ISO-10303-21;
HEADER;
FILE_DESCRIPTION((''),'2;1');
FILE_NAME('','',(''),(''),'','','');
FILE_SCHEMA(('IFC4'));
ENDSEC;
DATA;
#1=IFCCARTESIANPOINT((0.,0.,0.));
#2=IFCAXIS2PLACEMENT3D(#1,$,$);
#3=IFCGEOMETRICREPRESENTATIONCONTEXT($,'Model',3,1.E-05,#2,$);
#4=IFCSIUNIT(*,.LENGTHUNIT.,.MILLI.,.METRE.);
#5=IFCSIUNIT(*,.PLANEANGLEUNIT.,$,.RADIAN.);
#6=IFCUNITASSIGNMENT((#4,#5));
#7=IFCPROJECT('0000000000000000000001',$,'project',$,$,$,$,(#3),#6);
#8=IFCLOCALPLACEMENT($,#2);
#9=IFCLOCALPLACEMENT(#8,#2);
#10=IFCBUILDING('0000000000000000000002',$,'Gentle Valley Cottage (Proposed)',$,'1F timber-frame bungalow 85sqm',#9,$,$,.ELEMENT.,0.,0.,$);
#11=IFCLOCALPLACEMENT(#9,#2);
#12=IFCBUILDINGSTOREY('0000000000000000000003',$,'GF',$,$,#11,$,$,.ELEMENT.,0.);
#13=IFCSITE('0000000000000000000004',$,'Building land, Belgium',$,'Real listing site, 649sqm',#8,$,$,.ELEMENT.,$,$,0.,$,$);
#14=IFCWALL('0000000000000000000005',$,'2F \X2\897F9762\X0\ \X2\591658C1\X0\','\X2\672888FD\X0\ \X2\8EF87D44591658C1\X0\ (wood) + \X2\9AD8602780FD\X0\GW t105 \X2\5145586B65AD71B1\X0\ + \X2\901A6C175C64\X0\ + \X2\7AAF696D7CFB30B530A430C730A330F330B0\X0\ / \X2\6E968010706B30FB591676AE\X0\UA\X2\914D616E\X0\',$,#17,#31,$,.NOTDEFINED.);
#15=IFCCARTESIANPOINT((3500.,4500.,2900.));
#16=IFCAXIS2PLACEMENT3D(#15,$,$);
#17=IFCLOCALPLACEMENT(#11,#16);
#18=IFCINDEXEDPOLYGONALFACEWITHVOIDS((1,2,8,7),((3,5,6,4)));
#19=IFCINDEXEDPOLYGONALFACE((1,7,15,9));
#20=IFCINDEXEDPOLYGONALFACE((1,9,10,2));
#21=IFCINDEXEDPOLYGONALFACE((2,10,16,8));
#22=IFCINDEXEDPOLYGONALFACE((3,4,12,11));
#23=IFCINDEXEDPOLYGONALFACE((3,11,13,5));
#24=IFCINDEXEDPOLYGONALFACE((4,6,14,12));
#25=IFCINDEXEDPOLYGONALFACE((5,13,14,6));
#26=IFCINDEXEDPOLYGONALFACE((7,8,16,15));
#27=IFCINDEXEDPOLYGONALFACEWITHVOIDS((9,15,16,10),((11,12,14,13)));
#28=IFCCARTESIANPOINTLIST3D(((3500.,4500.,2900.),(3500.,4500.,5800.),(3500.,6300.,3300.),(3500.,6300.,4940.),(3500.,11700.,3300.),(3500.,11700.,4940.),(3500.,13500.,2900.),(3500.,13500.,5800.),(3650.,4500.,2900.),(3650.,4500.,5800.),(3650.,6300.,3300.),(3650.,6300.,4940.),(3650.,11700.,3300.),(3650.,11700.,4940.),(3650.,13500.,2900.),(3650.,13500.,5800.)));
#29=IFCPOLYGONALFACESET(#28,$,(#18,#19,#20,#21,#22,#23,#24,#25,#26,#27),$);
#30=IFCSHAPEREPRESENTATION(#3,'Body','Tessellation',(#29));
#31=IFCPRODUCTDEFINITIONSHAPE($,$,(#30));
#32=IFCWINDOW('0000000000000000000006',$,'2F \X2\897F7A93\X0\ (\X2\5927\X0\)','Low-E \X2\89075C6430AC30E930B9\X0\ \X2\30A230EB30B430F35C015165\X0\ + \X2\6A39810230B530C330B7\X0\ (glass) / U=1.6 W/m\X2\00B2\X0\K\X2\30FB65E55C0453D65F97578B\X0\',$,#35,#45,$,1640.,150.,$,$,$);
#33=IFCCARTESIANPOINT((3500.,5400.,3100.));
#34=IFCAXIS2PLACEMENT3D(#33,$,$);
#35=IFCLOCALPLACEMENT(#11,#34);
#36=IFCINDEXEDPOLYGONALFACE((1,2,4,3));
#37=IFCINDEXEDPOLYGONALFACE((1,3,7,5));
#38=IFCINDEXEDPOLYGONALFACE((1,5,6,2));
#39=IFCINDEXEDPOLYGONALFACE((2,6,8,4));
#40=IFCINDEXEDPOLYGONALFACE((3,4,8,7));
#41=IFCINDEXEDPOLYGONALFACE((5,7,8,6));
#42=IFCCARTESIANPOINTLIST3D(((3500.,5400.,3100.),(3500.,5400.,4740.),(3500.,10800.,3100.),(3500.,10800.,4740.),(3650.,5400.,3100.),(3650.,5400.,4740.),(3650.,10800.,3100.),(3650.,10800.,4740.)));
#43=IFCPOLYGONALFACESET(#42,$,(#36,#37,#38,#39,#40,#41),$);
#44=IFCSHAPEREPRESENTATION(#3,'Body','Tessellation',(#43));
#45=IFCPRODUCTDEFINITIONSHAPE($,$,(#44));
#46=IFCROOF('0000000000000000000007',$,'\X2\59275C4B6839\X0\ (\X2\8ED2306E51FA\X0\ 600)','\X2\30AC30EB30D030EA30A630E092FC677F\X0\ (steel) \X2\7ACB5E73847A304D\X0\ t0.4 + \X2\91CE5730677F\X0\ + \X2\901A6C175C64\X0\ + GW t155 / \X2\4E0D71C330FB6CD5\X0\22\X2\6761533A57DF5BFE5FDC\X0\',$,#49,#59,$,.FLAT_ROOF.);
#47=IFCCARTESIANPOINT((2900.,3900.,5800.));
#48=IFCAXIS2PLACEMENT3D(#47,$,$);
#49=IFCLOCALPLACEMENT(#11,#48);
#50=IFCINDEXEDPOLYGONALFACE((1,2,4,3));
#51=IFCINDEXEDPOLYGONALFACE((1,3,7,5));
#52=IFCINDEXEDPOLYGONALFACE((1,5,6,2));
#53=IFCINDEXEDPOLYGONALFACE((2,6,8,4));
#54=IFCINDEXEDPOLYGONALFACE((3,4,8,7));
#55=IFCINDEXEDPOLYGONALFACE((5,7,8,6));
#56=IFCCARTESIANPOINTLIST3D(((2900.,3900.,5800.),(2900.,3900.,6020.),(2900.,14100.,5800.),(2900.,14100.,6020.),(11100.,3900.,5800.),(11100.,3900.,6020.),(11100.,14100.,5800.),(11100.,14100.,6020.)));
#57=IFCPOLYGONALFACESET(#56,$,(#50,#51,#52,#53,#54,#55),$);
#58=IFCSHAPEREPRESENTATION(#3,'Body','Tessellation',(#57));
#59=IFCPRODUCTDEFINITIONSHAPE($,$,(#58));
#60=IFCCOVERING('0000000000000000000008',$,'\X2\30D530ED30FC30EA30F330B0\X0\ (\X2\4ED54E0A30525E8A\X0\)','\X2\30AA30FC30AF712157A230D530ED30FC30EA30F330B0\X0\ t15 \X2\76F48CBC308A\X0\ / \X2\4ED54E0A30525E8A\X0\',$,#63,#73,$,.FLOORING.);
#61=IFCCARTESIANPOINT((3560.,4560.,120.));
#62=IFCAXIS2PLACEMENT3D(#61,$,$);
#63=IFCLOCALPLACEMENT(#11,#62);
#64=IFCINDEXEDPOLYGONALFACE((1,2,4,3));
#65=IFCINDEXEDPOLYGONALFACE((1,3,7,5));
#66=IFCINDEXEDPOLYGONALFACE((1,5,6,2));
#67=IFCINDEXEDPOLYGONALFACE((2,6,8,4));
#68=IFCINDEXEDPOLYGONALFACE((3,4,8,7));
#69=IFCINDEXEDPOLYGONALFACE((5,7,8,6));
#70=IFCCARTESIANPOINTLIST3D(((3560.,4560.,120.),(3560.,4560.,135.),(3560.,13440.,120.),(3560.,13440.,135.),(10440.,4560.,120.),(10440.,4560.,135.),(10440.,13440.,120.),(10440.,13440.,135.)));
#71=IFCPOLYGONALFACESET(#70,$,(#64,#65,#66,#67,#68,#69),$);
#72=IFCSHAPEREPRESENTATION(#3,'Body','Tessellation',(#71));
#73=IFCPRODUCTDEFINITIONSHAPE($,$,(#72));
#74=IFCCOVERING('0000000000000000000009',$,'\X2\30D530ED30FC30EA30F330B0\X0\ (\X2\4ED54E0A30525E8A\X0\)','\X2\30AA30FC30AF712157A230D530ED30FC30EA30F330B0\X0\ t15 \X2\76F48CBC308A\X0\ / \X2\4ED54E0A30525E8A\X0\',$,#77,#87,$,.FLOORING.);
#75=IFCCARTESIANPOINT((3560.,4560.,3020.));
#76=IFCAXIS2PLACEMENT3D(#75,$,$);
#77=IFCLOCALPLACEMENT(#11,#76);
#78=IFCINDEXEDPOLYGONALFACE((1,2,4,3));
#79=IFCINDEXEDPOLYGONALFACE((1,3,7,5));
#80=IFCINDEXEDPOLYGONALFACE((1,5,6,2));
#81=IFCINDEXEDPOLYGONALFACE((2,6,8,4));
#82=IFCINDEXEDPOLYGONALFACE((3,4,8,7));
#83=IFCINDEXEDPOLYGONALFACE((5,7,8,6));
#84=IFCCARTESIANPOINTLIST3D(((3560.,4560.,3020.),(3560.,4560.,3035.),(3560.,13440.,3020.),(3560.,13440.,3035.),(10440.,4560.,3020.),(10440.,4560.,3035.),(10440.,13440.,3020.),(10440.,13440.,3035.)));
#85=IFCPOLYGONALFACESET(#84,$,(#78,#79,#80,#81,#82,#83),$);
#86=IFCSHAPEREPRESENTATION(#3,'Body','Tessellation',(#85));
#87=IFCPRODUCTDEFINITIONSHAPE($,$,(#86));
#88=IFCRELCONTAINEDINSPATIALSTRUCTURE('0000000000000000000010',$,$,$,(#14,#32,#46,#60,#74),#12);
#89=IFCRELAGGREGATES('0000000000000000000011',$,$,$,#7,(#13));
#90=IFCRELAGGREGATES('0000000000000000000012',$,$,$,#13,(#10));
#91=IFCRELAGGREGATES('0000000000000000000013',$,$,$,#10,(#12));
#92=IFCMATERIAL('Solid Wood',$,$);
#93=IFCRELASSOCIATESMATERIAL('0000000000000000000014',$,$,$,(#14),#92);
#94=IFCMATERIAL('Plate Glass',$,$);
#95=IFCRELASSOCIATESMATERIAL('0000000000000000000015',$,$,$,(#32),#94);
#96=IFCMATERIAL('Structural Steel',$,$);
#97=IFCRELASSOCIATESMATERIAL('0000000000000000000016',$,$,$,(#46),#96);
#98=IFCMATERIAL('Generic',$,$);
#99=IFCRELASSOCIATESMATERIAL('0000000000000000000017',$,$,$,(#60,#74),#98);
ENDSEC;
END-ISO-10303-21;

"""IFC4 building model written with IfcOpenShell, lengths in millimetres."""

from ifc_helpers import new_model, si_unit, frame, frame_2d, origin, place, context, project, spatial, rectangle, extrude, material, element, fill, save


model = new_model("IFC4")

# Units and contexts
model_context = context("Model", 3, precision=1e-05, world=origin())
ifc_project = project(units=[si_unit("LENGTHUNIT", "METRE", prefix="MILLI"), si_unit("PLANEANGLEUNIT", "RADIAN")], contexts=[model_context])

# Site, building, storey
site_placement = place(None, origin())
site = spatial("IfcSite", under=ifc_project, at=site_placement, Name="Building land, Belgium", ObjectType="Real listing site, 649sqm", CompositionType="ELEMENT", RefElevation=0.0)
building_placement = place(site_placement, origin())
building = spatial("IfcBuilding", under=site, at=building_placement, Name="Gentle Valley Cottage (Proposed)", ObjectType="1F timber-frame bungalow 85sqm", CompositionType="ELEMENT", ElevationOfRefHeight=0.0, ElevationOfTerrain=0.0)
storey_placement = place(building_placement, origin())
storey = spatial("IfcBuildingStorey", under=building, at=storey_placement, Name="GF", CompositionType="ELEMENT", Elevation=0.0)

# Shared definitions
ifc_material_1 = material(Name="Solid Wood")
ifc_material_2 = material(Name="Generic")

# Shared definitions
ifc_material_3 = material(Name="Plate Glass")

# Wall, opening, window
wall_1_placement = place(storey_placement, frame((3500.0, 4500.0, 2900.0)))
wall_1 = element("IfcWall", 1, at=wall_1_placement, inside=storey, material=ifc_material_1, Name="2F 西面 外壁", Description="木製 軸組外壁 (wood) + 高性能GW t105 充填断熱 + 通気層 + 窯業系サイディング / 準耐火・外皮UA配慮", PredefinedType="NOTDEFINED", context=model_context, shape_type="SweptSolid", body=[
    extrude(rectangle(XDim=150.0, YDim=9000.0, at=frame_2d((75.0, 4500.0))), frame((3500.0, 4500.0, 2900.0)), (0.0, 0.0, 1.0), 2900.0),
])
opening_1_placement = place(storey_placement, frame((3500.0, 5400.0, 3100.0)))
opening_1 = element("IfcOpeningElement", 2, at=opening_1_placement, cuts=wall_1, PredefinedType="NOTDEFINED", context=model_context, shape_type="SweptSolid", body=[
    extrude(rectangle(XDim=150.0, YDim=5400.0, at=frame_2d((75.0, 2700.0))), frame((3500.0, 5400.0, 3100.0)), (0.0, 0.0, 1.0), 1640.0),
])
window_1_placement = place(storey_placement, frame((3500.0, 5400.0, 3100.0)))
window_1 = element("IfcWindow", 3, at=window_1_placement, inside=storey, material=ifc_material_3, Name="2F 西窓 (大)", Description="Low-E 複層ガラス アルゴン封入 + 樹脂サッシ (glass) / U=1.6 W/m²K・日射取得型", OverallHeight=1640.0, OverallWidth=150.0, context=model_context, shape_type="SweptSolid", body=[
    extrude(rectangle(XDim=150.0, YDim=5400.0, at=frame_2d((75.0, 2700.0))), frame((3500.0, 5400.0, 3100.0)), (0.0, 0.0, 1.0), 1640.0),
])
fill(opening_1, window_1)

# Roof
ifc_material_4 = material(Name="Structural Steel")
roof_placement = place(storey_placement, frame((2900.0, 3900.0, 5800.0)))
element("IfcRoof", 4, at=roof_placement, inside=storey, material=ifc_material_4, Name="大屋根 (軒の出 600)", Description="ガルバリウム鋼板 (steel) 立平葺き t0.4 + 野地板 + 通気層 + GW t155 / 不燃・法22条区域対応", PredefinedType="FLAT_ROOF", context=model_context, shape_type="SweptSolid", body=[
    extrude(rectangle(XDim=8200.0, YDim=10200.0, at=frame_2d((4100.0, 5100.0))), frame((2900.0, 3900.0, 5800.0)), (0.0, 0.0, 1.0), 220.0),
])

# Coverings
covering_1_placement = place(storey_placement, frame((3560.0, 4560.0, 120.0)))
element("IfcCovering", 5, at=covering_1_placement, inside=storey, material=ifc_material_2, Name="フローリング (仕上げ床)", Description="オーク無垢フローリング t15 直貼り / 仕上げ床", PredefinedType="FLOORING", context=model_context, shape_type="SweptSolid", body=[
    extrude(rectangle(XDim=6880.0, YDim=8880.0, at=frame_2d((3440.0, 4440.0))), frame((3560.0, 4560.0, 120.0)), (0.0, 0.0, 1.0), 15.0),
])
covering_2_placement = place(storey_placement, frame((3560.0, 4560.0, 3020.0)))
element("IfcCovering", 6, at=covering_2_placement, inside=storey, material=ifc_material_2, Name="フローリング (仕上げ床)", Description="オーク無垢フローリング t15 直貼り / 仕上げ床", PredefinedType="FLOORING", context=model_context, shape_type="SweptSolid", body=[
    extrude(rectangle(XDim=6880.0, YDim=8880.0, at=frame_2d((3440.0, 4440.0))), frame((3560.0, 4560.0, 3020.0)), (0.0, 0.0, 1.0), 15.0),
])

save(model, "model.ifc")
